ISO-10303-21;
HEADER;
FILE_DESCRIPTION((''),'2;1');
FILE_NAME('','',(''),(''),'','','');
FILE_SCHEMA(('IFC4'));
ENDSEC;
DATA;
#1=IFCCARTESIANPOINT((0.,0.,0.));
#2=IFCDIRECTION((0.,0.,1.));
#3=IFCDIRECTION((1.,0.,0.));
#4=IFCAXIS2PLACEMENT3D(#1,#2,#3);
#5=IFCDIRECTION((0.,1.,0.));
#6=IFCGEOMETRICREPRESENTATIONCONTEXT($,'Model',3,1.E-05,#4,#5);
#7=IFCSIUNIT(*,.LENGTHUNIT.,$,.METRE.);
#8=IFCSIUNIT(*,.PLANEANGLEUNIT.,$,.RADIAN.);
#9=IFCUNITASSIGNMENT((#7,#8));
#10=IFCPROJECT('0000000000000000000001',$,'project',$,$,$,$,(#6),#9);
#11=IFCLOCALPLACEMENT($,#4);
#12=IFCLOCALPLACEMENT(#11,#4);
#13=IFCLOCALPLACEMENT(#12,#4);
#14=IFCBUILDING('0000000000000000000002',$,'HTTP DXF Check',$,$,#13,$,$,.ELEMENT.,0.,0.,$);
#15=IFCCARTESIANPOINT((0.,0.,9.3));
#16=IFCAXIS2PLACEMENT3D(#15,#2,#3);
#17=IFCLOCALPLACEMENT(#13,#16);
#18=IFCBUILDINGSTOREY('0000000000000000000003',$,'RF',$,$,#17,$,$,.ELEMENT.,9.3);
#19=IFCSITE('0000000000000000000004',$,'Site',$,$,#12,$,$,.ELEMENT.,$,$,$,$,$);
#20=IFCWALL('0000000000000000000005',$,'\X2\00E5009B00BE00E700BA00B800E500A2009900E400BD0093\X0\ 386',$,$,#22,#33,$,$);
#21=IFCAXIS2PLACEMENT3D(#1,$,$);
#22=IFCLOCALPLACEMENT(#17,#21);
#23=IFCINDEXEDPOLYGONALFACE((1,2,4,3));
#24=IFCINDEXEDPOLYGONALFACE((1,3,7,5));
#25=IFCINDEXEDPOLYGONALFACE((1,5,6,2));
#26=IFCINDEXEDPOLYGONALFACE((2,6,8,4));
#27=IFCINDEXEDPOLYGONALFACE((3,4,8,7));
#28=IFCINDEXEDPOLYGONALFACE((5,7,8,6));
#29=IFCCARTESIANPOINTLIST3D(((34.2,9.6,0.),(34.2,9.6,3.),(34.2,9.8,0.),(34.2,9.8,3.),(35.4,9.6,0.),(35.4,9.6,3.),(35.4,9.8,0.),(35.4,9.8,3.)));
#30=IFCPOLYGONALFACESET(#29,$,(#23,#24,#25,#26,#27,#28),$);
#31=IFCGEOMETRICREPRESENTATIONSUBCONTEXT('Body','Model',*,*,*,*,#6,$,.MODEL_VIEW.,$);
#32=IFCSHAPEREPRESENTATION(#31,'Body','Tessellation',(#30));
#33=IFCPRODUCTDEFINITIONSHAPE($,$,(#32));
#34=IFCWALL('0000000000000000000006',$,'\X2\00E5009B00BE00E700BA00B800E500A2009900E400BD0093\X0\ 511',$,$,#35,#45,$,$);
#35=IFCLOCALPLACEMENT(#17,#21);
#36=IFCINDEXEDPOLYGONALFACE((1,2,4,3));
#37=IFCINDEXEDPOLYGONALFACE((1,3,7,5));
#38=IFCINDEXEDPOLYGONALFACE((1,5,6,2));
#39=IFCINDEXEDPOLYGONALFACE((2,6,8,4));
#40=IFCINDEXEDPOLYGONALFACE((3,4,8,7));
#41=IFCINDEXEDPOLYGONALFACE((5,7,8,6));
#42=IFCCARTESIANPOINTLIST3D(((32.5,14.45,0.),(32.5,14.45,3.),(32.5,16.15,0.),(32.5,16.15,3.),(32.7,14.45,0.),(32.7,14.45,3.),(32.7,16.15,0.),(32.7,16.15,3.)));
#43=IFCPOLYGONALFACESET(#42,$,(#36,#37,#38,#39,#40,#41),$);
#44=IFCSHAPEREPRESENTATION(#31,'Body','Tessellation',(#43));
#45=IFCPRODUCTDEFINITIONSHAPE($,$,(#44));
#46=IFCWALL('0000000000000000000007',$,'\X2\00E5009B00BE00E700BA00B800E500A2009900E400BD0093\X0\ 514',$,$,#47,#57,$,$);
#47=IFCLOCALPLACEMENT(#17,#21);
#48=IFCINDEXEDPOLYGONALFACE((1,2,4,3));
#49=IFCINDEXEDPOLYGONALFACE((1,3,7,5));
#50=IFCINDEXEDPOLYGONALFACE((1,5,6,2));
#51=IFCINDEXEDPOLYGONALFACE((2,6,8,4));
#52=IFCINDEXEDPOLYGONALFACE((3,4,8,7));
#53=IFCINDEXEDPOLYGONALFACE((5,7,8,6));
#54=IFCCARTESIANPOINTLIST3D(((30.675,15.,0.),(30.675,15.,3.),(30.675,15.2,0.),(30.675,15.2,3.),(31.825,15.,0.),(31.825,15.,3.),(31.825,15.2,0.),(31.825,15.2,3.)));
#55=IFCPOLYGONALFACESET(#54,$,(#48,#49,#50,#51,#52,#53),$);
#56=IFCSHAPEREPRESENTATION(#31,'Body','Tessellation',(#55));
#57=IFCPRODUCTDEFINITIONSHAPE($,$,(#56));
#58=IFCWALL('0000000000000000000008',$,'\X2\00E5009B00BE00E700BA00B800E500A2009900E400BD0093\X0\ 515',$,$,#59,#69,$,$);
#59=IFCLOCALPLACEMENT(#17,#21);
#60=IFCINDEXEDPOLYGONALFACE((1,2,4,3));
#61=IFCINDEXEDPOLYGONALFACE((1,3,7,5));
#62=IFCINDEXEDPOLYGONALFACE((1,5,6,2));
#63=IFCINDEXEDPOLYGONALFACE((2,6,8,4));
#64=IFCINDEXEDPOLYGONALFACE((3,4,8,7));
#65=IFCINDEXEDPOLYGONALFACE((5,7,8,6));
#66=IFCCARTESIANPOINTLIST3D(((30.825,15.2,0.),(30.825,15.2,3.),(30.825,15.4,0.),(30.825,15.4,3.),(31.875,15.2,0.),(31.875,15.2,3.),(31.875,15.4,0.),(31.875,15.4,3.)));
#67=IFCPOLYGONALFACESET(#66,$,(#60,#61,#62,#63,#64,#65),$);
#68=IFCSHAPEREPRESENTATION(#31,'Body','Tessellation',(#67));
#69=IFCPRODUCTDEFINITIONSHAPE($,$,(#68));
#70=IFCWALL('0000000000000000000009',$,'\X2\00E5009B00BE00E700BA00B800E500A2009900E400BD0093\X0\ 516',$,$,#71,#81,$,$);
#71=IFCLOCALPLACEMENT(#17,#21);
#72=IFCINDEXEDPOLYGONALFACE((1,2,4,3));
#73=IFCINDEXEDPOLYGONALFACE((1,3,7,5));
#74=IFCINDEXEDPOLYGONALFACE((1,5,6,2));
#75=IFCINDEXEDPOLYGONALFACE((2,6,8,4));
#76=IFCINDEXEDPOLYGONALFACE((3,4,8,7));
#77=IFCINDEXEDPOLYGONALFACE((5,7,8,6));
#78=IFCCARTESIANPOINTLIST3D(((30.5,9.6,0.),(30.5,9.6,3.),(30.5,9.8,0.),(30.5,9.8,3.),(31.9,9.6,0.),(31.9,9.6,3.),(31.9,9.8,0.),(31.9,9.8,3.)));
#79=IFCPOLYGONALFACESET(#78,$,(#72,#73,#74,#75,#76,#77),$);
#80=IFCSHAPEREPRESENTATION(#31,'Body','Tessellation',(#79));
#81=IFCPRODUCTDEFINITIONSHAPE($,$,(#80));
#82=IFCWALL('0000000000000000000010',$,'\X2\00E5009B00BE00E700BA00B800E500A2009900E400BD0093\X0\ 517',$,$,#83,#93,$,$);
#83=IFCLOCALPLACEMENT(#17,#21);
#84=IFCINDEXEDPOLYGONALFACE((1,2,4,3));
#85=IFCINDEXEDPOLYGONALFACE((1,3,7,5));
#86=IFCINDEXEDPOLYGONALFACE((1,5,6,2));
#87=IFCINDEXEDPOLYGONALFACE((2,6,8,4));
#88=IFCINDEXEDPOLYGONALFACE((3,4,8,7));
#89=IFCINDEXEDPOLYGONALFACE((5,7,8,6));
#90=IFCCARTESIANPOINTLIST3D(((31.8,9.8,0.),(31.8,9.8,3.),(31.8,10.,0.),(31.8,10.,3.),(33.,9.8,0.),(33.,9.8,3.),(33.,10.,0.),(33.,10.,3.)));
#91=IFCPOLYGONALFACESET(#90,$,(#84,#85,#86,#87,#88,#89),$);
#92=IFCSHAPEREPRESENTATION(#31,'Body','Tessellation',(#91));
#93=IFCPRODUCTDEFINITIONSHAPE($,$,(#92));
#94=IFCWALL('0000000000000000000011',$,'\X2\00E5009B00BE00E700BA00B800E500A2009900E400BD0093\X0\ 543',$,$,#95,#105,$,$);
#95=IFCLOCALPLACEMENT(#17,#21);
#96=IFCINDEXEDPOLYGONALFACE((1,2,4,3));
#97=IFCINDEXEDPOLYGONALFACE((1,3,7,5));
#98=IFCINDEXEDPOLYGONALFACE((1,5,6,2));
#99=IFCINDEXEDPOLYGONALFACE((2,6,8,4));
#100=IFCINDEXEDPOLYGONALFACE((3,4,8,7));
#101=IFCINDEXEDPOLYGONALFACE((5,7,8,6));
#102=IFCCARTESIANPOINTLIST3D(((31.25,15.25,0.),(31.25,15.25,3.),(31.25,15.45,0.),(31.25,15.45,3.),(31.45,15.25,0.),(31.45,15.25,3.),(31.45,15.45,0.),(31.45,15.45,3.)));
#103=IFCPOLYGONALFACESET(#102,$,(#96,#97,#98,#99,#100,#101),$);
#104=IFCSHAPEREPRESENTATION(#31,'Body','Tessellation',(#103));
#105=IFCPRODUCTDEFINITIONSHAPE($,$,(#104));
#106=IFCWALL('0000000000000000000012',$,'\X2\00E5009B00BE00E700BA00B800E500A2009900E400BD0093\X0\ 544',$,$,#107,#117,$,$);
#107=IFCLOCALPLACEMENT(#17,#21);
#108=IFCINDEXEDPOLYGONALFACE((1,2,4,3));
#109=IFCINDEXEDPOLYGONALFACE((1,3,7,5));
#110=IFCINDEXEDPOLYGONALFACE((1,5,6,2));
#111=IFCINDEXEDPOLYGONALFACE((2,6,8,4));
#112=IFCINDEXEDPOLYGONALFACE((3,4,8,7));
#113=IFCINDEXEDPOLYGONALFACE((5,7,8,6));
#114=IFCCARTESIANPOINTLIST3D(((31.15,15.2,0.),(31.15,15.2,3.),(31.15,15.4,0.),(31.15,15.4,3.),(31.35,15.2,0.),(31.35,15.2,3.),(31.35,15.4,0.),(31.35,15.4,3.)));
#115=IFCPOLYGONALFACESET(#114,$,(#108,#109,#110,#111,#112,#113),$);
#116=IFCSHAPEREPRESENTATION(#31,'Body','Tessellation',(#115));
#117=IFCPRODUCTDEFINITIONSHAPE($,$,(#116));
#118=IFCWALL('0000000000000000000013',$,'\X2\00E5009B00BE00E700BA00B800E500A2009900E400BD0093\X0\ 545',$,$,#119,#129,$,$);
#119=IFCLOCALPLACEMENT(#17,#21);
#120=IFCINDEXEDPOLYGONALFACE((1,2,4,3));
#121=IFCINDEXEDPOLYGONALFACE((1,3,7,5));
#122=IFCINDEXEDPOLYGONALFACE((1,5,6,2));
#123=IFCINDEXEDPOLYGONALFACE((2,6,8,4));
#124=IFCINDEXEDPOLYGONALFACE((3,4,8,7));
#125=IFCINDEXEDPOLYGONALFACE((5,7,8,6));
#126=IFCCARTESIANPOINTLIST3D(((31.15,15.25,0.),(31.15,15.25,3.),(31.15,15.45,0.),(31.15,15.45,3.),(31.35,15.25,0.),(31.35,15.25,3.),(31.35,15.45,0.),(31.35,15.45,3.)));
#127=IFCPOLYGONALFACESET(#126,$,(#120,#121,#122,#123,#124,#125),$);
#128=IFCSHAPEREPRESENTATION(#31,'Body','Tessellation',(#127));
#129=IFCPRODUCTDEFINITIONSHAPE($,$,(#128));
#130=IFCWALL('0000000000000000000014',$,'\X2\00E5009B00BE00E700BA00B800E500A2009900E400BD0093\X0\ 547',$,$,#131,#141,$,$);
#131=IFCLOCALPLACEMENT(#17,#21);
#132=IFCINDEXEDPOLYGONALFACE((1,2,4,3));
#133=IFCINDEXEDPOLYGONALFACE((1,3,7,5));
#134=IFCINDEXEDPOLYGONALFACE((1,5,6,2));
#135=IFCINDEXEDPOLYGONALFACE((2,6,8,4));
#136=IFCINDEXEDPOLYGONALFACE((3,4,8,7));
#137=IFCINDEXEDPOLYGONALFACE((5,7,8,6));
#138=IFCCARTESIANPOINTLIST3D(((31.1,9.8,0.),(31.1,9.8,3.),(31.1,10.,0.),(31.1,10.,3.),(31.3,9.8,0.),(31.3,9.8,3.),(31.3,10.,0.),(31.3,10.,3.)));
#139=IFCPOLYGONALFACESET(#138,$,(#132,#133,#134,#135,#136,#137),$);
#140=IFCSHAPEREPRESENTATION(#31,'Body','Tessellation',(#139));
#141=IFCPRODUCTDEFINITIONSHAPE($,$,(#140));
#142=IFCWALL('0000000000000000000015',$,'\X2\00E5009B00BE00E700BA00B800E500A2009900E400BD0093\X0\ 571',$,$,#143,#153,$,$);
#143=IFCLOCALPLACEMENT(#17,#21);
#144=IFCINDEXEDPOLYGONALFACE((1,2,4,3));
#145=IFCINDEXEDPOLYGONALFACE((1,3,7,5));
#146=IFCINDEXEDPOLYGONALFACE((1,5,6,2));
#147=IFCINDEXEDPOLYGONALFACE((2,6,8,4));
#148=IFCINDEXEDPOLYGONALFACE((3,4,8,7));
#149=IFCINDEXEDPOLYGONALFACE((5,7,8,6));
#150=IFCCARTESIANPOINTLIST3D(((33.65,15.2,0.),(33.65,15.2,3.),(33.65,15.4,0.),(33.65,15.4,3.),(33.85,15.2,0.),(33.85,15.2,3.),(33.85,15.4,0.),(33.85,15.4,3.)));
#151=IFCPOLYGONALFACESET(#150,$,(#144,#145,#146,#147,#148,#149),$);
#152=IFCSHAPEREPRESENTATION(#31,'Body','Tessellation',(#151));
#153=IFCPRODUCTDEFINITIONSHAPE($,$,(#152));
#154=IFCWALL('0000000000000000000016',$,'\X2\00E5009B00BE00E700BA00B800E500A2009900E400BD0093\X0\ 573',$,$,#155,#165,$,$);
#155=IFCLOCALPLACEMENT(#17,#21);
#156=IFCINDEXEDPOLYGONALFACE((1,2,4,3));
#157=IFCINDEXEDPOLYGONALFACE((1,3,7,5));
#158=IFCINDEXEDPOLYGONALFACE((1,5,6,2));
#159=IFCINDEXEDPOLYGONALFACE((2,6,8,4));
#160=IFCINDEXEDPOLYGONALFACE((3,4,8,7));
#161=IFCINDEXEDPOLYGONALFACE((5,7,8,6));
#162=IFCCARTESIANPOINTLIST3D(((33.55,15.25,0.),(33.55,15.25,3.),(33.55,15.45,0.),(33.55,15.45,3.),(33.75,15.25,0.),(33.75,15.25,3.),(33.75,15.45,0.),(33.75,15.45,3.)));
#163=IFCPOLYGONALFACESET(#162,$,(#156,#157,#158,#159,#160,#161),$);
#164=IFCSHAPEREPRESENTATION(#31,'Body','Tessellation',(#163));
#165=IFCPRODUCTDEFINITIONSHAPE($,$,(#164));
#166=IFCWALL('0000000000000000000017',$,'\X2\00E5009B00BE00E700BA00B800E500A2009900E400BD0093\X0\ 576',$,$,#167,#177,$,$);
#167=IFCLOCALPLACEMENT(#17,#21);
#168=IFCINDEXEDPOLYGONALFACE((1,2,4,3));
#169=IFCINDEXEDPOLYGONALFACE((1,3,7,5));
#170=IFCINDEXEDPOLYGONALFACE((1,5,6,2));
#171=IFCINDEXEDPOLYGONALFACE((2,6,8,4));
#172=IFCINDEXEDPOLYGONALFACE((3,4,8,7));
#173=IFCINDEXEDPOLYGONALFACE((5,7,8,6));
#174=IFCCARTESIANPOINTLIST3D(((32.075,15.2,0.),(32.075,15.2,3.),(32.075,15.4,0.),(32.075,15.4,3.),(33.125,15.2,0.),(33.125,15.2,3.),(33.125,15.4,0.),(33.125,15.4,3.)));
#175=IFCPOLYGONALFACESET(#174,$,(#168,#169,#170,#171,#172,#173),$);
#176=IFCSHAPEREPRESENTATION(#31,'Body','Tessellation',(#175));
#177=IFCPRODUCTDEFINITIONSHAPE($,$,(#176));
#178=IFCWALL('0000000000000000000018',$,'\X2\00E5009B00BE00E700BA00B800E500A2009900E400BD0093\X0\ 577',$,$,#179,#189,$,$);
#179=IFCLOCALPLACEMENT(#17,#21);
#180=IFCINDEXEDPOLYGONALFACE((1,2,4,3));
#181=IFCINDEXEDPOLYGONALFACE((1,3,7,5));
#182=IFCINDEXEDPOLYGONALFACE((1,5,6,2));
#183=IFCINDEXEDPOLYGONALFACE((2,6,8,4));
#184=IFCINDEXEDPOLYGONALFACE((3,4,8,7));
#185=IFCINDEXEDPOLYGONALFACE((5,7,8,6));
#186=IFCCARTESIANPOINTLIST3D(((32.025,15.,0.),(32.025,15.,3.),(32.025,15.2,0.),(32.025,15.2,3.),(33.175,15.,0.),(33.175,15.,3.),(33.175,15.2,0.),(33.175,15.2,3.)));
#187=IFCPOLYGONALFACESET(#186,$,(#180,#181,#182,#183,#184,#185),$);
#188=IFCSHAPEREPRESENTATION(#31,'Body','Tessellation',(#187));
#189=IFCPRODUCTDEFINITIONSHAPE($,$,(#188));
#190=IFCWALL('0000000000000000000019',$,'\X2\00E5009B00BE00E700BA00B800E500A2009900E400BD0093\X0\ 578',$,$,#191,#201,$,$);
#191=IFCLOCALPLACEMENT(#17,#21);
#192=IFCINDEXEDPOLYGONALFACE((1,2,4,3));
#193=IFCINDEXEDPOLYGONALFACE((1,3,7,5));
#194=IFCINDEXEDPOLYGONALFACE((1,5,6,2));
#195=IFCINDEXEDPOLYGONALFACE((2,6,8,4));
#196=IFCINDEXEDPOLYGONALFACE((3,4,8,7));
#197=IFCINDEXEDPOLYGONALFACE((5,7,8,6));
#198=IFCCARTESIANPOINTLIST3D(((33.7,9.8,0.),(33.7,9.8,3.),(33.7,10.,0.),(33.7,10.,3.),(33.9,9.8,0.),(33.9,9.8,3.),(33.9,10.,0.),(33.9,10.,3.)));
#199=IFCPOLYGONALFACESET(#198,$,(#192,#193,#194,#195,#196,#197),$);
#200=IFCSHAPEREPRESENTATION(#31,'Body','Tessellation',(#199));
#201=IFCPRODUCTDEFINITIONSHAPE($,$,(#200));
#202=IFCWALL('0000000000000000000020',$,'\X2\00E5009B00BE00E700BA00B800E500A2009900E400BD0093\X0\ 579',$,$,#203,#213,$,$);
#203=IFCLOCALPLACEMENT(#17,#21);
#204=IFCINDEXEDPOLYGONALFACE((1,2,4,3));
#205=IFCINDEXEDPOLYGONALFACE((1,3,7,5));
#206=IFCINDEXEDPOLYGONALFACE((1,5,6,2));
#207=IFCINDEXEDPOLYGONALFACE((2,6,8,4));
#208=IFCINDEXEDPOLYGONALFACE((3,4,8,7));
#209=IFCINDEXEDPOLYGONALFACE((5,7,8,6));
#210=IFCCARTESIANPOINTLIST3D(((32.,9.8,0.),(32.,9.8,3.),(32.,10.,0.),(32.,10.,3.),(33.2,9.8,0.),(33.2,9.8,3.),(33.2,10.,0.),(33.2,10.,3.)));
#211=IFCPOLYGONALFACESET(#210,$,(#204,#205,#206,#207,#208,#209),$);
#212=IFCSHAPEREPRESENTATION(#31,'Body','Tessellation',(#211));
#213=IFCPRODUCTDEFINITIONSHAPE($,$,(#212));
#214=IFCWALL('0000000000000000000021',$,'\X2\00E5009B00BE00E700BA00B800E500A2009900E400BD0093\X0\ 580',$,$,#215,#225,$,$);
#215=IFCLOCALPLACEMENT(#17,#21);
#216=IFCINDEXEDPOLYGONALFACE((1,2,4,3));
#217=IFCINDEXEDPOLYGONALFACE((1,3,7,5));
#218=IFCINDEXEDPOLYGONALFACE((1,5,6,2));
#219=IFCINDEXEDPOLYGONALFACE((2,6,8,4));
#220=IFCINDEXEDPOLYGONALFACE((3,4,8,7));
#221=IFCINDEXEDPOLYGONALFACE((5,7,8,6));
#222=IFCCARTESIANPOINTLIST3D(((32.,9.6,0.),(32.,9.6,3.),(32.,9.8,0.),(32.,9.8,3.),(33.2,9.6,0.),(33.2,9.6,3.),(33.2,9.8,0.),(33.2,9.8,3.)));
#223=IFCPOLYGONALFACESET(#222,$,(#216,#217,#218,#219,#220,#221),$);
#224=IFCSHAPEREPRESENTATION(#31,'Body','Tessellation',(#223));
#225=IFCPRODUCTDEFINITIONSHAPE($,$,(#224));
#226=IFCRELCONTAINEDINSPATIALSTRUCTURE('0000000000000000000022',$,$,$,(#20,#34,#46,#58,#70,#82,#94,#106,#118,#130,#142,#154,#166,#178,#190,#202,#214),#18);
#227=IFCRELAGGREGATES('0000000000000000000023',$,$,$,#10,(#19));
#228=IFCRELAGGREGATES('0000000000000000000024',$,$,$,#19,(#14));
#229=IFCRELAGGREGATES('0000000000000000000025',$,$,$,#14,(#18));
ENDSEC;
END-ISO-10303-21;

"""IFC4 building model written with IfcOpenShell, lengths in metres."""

from ifc_helpers import new_model, si_unit, direction, frame, frame_2d, origin_with_axes, place, context, subcontext, project, spatial, rectangle, extrude, element, save


model = new_model("IFC4")

# Units and contexts
model_context = context("Model", 3, precision=1e-05, world=origin_with_axes(), true_north=direction((0.0, 1.0, 0.0)))
body_context = subcontext(model_context, "Body", "Model", "MODEL_VIEW")
ifc_project = project(units=[si_unit("LENGTHUNIT", "METRE"), si_unit("PLANEANGLEUNIT", "RADIAN")], contexts=[model_context])

# Site, building, storey
placement = place(None, origin_with_axes())
site_placement = place(placement, origin_with_axes())
site = spatial("IfcSite", under=ifc_project, at=site_placement, Name="Site", CompositionType="ELEMENT")
building_placement = place(site_placement, origin_with_axes())
building = spatial("IfcBuilding", under=site, at=building_placement, Name="HTTP DXF Check", CompositionType="ELEMENT", ElevationOfRefHeight=0.0, ElevationOfTerrain=0.0)
storey_placement = place(building_placement, frame((0.0, 0.0, 9.3), z_axis=(0.0, 0.0, 1.0), x_axis=(1.0, 0.0, 0.0)))
storey = spatial("IfcBuildingStorey", under=building, at=storey_placement, Name="RF", CompositionType="ELEMENT", Elevation=9.3)

# Walls
wall_1_placement = place(storey_placement, frame((34.8, 9.7, 0.0), z_axis=(0.0, 0.0, 1.0), x_axis=(1.0, 0.0, 0.0)))
element("IfcWall", 1, at=wall_1_placement, inside=storey, Name="å\u009b¾çº¸å¢\u0099ä½\u0093 386", context=body_context, shape_type="SweptSolid", body=[
    extrude(rectangle(XDim=1.2, YDim=0.2, at=frame_2d((0.0, 0.0), x_axis=(1.0, 0.0, 0.0))), frame((0.0, 0.0, 0.0), z_axis=(0.0, 0.0, 1.0)), (0.0, 0.0, 1.0), 3.0),
])
wall_2_placement = place(storey_placement, frame((32.6, 15.3, 0.0), z_axis=(0.0, 0.0, 1.0), x_axis=(0.0, 1.0, 0.0)))
element("IfcWall", 2, at=wall_2_placement, inside=storey, Name="å\u009b¾çº¸å¢\u0099ä½\u0093 511", context=body_context, shape_type="SweptSolid", body=[
    extrude(rectangle(XDim=1.7, YDim=0.2, at=frame_2d((0.0, 0.0), x_axis=(1.0, 0.0, 0.0))), frame((0.0, 0.0, 0.0), z_axis=(0.0, 0.0, 1.0)), (0.0, 0.0, 1.0), 3.0),
])
wall_3_placement = place(storey_placement, frame((31.25, 15.1, 0.0), z_axis=(0.0, 0.0, 1.0), x_axis=(1.0, 0.0, 0.0)))
element("IfcWall", 3, at=wall_3_placement, inside=storey, Name="å\u009b¾çº¸å¢\u0099ä½\u0093 514", context=body_context, shape_type="SweptSolid", body=[
    extrude(rectangle(XDim=1.15, YDim=0.2, at=frame_2d((0.0, 0.0), x_axis=(1.0, 0.0, 0.0))), frame((0.0, 0.0, 0.0), z_axis=(0.0, 0.0, 1.0)), (0.0, 0.0, 1.0), 3.0),
])
wall_4_placement = place(storey_placement, frame((31.35, 15.3, 0.0), z_axis=(0.0, 0.0, 1.0), x_axis=(1.0, 0.0, 0.0)))
element("IfcWall", 4, at=wall_4_placement, inside=storey, Name="å\u009b¾çº¸å¢\u0099ä½\u0093 515", context=body_context, shape_type="SweptSolid", body=[
    extrude(rectangle(XDim=1.05, YDim=0.2, at=frame_2d((0.0, 0.0), x_axis=(1.0, 0.0, 0.0))), frame((0.0, 0.0, 0.0), z_axis=(0.0, 0.0, 1.0)), (0.0, 0.0, 1.0), 3.0),
])
wall_5_placement = place(storey_placement, frame((31.2, 9.7, 0.0), z_axis=(0.0, 0.0, 1.0), x_axis=(1.0, 0.0, 0.0)))
element("IfcWall", 5, at=wall_5_placement, inside=storey, Name="å\u009b¾çº¸å¢\u0099ä½\u0093 516", context=body_context, shape_type="SweptSolid", body=[
    extrude(rectangle(XDim=1.4, YDim=0.2, at=frame_2d((0.0, 0.0), x_axis=(1.0, 0.0, 0.0))), frame((0.0, 0.0, 0.0), z_axis=(0.0, 0.0, 1.0)), (0.0, 0.0, 1.0), 3.0),
])
wall_6_placement = place(storey_placement, frame((32.4, 9.9, 0.0), z_axis=(0.0, 0.0, 1.0), x_axis=(-1.0, 0.0, 0.0)))
element("IfcWall", 6, at=wall_6_placement, inside=storey, Name="å\u009b¾çº¸å¢\u0099ä½\u0093 517", context=body_context, shape_type="SweptSolid", body=[
    extrude(rectangle(XDim=1.2, YDim=0.2, at=frame_2d((0.0, 0.0), x_axis=(1.0, 0.0, 0.0))), frame((0.0, 0.0, 0.0), z_axis=(0.0, 0.0, 1.0)), (0.0, 0.0, 1.0), 3.0),
])
for number, where, z_axis, x_axis, name in (
    (7, (31.35, 15.35, 0.0), (0.0, 0.0, 1.0), (-1.0, 0.0, 0.0), "å\u009b¾çº¸å¢\u0099ä½\u0093 543"),
    (8, (31.25, 15.3, 0.0), (0.0, 0.0, 1.0), (0.0, -1.0, 0.0), "å\u009b¾çº¸å¢\u0099ä½\u0093 544"),
    (9, (31.25, 15.35, 0.0), (0.0, 0.0, 1.0), (0.0, -1.0, 0.0), "å\u009b¾çº¸å¢\u0099ä½\u0093 545"),
    (10, (31.2, 9.9, 0.0), (0.0, 0.0, 1.0), (0.0, -1.0, 0.0), "å\u009b¾çº¸å¢\u0099ä½\u0093 547"),
    (11, (33.75, 15.3, 0.0), (0.0, 0.0, 1.0), (0.0, -1.0, 0.0), "å\u009b¾çº¸å¢\u0099ä½\u0093 571"),
    (12, (33.65, 15.35, 0.0), (0.0, 0.0, 1.0), (1.0, 0.0, 0.0), "å\u009b¾çº¸å¢\u0099ä½\u0093 573"),
):
    element("IfcWall", number, at=place(storey_placement, frame(where, z_axis=z_axis, x_axis=x_axis)), inside=storey, Name=name, context=body_context, shape_type="SweptSolid", body=[
        extrude(rectangle(XDim=0.2, YDim=0.2, at=frame_2d((0.0, 0.0), x_axis=(1.0, 0.0, 0.0))), frame((0.0, 0.0, 0.0), z_axis=(0.0, 0.0, 1.0)), (0.0, 0.0, 1.0), 3.0),
    ])
wall_7_placement = place(storey_placement, frame((32.6, 15.3, 0.0), z_axis=(0.0, 0.0, 1.0), x_axis=(1.0, 0.0, 0.0)))
element("IfcWall", 13, at=wall_7_placement, inside=storey, Name="å\u009b¾çº¸å¢\u0099ä½\u0093 576", context=body_context, shape_type="SweptSolid", body=[
    extrude(rectangle(XDim=1.05, YDim=0.2, at=frame_2d((0.0, 0.0), x_axis=(1.0, 0.0, 0.0))), frame((0.0, 0.0, 0.0), z_axis=(0.0, 0.0, 1.0)), (0.0, 0.0, 1.0), 3.0),
])
wall_8_placement = place(storey_placement, frame((32.6, 15.1, 0.0), z_axis=(0.0, 0.0, 1.0), x_axis=(1.0, 0.0, 0.0)))
element("IfcWall", 14, at=wall_8_placement, inside=storey, Name="å\u009b¾çº¸å¢\u0099ä½\u0093 577", context=body_context, shape_type="SweptSolid", body=[
    extrude(rectangle(XDim=1.15, YDim=0.2, at=frame_2d((0.0, 0.0), x_axis=(1.0, 0.0, 0.0))), frame((0.0, 0.0, 0.0), z_axis=(0.0, 0.0, 1.0)), (0.0, 0.0, 1.0), 3.0),
])
wall_9_placement = place(storey_placement, frame((33.8, 9.9, 0.0), z_axis=(0.0, 0.0, 1.0), x_axis=(0.0, -1.0, 0.0)))
element("IfcWall", 15, at=wall_9_placement, inside=storey, Name="å\u009b¾çº¸å¢\u0099ä½\u0093 578", context=body_context, shape_type="SweptSolid", body=[
    extrude(rectangle(XDim=0.2, YDim=0.2, at=frame_2d((0.0, 0.0), x_axis=(1.0, 0.0, 0.0))), frame((0.0, 0.0, 0.0), z_axis=(0.0, 0.0, 1.0)), (0.0, 0.0, 1.0), 3.0),
])
for number, where, z_axis, x_axis, name in (
    (16, (32.6, 9.9, 0.0), (0.0, 0.0, 1.0), (1.0, 0.0, 0.0), "å\u009b¾çº¸å¢\u0099ä½\u0093 579"),
    (17, (32.6, 9.7, 0.0), (0.0, 0.0, 1.0), (1.0, 0.0, 0.0), "å\u009b¾çº¸å¢\u0099ä½\u0093 580"),
):
    element("IfcWall", number, at=place(storey_placement, frame(where, z_axis=z_axis, x_axis=x_axis)), inside=storey, Name=name, context=body_context, shape_type="SweptSolid", body=[
        extrude(rectangle(XDim=1.2, YDim=0.2, at=frame_2d((0.0, 0.0), x_axis=(1.0, 0.0, 0.0))), frame((0.0, 0.0, 0.0), z_axis=(0.0, 0.0, 1.0)), (0.0, 0.0, 1.0), 3.0),
    ])

save(model, "model.ifc")
